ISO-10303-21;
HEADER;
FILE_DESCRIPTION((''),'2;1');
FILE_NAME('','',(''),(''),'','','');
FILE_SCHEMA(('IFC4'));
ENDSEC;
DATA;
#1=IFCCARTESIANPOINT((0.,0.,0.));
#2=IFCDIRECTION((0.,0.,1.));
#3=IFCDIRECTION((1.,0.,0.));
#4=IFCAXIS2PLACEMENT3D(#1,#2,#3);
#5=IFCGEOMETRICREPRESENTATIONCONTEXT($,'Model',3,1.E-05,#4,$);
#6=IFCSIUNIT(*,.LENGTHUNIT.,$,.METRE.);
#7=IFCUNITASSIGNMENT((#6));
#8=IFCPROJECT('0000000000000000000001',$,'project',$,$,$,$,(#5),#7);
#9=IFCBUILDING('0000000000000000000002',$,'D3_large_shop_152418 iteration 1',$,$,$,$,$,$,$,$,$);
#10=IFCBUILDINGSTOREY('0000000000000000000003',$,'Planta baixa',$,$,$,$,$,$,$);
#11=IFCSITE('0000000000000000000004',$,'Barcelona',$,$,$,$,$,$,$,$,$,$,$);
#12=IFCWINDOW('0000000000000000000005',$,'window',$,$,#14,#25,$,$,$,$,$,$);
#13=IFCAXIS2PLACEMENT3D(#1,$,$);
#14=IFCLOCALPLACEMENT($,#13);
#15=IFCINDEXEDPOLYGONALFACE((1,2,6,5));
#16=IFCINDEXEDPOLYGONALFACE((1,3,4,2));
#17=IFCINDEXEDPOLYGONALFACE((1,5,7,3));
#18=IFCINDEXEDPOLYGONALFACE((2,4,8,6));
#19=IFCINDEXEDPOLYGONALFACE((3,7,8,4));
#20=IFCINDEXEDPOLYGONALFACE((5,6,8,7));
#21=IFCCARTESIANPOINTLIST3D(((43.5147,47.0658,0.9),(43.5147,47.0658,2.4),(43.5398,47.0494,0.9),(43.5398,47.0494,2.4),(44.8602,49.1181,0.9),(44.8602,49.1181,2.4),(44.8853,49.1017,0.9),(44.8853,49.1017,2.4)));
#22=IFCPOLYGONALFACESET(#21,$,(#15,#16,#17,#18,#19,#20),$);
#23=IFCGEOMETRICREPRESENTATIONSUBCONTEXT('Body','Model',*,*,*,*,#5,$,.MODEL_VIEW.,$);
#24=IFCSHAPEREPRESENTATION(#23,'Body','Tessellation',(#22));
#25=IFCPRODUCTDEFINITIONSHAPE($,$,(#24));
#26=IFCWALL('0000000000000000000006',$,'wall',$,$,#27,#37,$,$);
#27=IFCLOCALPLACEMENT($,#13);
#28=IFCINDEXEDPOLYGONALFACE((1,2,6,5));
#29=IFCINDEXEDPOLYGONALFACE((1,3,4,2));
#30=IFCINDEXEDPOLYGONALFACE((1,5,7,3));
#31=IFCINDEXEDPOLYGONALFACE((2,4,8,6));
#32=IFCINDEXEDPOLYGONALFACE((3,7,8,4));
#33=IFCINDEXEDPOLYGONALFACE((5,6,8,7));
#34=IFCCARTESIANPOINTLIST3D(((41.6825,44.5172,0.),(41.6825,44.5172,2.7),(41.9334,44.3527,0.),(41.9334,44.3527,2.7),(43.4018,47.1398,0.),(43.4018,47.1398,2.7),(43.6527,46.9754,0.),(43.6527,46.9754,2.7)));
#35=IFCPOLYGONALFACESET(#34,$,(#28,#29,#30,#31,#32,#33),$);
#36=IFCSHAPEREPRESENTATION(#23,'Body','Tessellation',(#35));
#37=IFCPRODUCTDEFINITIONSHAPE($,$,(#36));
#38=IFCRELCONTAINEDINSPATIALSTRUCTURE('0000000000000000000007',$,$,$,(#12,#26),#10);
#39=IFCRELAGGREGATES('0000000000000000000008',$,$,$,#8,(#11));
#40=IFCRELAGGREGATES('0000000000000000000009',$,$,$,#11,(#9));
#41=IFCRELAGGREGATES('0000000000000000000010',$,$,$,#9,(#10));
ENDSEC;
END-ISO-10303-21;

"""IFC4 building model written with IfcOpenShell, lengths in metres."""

from ifc_helpers import new_model, si_unit, frame, origin, origin_with_axes, place, context, subcontext, project, spatial, polyline, outline, extrude, element, save


model = new_model("IFC4")

# Units and contexts
model_context = context("Model", 3, precision=1e-05, world=origin_with_axes())
body_context = subcontext(model_context, "Body", "Model", "MODEL_VIEW")
ifc_project = project(units=[si_unit("LENGTHUNIT", "METRE")], contexts=[model_context])

# Site, building, storey
site = spatial("IfcSite", under=ifc_project, Name="Barcelona")
building = spatial("IfcBuilding", under=site, Name="D3_large_shop_152418 iteration 1")
storey = spatial("IfcBuildingStorey", under=building, Name="Planta baixa")

# Window
window_1_placement = place(None, origin_with_axes())
element("IfcWindow", 1, at=window_1_placement, inside=storey, Name="window", context=body_context, shape_type="SweptSolid", body=[
    extrude(outline(polyline([(44.8853, 49.1017), (43.5398, 47.0494), (43.5147, 47.0658), (44.8602, 49.1181), (44.8853, 49.1017)])), frame((0.0, 0.0, 0.9)), (0.0, 0.0, 1.0), 1.5),
])

# Wall
wall_1_placement = place(None, origin_with_axes())
element("IfcWall", 2, at=wall_1_placement, inside=storey, Name="wall", context=body_context, shape_type="SweptSolid", body=[
    extrude(outline(polyline([(43.6527, 46.9754), (41.9334, 44.3527), (41.6825, 44.5172), (43.4018, 47.1398), (43.6527, 46.9754)])), origin(), (0.0, 0.0, 1.0), 2.7),
])

save(model, "model.ifc")
